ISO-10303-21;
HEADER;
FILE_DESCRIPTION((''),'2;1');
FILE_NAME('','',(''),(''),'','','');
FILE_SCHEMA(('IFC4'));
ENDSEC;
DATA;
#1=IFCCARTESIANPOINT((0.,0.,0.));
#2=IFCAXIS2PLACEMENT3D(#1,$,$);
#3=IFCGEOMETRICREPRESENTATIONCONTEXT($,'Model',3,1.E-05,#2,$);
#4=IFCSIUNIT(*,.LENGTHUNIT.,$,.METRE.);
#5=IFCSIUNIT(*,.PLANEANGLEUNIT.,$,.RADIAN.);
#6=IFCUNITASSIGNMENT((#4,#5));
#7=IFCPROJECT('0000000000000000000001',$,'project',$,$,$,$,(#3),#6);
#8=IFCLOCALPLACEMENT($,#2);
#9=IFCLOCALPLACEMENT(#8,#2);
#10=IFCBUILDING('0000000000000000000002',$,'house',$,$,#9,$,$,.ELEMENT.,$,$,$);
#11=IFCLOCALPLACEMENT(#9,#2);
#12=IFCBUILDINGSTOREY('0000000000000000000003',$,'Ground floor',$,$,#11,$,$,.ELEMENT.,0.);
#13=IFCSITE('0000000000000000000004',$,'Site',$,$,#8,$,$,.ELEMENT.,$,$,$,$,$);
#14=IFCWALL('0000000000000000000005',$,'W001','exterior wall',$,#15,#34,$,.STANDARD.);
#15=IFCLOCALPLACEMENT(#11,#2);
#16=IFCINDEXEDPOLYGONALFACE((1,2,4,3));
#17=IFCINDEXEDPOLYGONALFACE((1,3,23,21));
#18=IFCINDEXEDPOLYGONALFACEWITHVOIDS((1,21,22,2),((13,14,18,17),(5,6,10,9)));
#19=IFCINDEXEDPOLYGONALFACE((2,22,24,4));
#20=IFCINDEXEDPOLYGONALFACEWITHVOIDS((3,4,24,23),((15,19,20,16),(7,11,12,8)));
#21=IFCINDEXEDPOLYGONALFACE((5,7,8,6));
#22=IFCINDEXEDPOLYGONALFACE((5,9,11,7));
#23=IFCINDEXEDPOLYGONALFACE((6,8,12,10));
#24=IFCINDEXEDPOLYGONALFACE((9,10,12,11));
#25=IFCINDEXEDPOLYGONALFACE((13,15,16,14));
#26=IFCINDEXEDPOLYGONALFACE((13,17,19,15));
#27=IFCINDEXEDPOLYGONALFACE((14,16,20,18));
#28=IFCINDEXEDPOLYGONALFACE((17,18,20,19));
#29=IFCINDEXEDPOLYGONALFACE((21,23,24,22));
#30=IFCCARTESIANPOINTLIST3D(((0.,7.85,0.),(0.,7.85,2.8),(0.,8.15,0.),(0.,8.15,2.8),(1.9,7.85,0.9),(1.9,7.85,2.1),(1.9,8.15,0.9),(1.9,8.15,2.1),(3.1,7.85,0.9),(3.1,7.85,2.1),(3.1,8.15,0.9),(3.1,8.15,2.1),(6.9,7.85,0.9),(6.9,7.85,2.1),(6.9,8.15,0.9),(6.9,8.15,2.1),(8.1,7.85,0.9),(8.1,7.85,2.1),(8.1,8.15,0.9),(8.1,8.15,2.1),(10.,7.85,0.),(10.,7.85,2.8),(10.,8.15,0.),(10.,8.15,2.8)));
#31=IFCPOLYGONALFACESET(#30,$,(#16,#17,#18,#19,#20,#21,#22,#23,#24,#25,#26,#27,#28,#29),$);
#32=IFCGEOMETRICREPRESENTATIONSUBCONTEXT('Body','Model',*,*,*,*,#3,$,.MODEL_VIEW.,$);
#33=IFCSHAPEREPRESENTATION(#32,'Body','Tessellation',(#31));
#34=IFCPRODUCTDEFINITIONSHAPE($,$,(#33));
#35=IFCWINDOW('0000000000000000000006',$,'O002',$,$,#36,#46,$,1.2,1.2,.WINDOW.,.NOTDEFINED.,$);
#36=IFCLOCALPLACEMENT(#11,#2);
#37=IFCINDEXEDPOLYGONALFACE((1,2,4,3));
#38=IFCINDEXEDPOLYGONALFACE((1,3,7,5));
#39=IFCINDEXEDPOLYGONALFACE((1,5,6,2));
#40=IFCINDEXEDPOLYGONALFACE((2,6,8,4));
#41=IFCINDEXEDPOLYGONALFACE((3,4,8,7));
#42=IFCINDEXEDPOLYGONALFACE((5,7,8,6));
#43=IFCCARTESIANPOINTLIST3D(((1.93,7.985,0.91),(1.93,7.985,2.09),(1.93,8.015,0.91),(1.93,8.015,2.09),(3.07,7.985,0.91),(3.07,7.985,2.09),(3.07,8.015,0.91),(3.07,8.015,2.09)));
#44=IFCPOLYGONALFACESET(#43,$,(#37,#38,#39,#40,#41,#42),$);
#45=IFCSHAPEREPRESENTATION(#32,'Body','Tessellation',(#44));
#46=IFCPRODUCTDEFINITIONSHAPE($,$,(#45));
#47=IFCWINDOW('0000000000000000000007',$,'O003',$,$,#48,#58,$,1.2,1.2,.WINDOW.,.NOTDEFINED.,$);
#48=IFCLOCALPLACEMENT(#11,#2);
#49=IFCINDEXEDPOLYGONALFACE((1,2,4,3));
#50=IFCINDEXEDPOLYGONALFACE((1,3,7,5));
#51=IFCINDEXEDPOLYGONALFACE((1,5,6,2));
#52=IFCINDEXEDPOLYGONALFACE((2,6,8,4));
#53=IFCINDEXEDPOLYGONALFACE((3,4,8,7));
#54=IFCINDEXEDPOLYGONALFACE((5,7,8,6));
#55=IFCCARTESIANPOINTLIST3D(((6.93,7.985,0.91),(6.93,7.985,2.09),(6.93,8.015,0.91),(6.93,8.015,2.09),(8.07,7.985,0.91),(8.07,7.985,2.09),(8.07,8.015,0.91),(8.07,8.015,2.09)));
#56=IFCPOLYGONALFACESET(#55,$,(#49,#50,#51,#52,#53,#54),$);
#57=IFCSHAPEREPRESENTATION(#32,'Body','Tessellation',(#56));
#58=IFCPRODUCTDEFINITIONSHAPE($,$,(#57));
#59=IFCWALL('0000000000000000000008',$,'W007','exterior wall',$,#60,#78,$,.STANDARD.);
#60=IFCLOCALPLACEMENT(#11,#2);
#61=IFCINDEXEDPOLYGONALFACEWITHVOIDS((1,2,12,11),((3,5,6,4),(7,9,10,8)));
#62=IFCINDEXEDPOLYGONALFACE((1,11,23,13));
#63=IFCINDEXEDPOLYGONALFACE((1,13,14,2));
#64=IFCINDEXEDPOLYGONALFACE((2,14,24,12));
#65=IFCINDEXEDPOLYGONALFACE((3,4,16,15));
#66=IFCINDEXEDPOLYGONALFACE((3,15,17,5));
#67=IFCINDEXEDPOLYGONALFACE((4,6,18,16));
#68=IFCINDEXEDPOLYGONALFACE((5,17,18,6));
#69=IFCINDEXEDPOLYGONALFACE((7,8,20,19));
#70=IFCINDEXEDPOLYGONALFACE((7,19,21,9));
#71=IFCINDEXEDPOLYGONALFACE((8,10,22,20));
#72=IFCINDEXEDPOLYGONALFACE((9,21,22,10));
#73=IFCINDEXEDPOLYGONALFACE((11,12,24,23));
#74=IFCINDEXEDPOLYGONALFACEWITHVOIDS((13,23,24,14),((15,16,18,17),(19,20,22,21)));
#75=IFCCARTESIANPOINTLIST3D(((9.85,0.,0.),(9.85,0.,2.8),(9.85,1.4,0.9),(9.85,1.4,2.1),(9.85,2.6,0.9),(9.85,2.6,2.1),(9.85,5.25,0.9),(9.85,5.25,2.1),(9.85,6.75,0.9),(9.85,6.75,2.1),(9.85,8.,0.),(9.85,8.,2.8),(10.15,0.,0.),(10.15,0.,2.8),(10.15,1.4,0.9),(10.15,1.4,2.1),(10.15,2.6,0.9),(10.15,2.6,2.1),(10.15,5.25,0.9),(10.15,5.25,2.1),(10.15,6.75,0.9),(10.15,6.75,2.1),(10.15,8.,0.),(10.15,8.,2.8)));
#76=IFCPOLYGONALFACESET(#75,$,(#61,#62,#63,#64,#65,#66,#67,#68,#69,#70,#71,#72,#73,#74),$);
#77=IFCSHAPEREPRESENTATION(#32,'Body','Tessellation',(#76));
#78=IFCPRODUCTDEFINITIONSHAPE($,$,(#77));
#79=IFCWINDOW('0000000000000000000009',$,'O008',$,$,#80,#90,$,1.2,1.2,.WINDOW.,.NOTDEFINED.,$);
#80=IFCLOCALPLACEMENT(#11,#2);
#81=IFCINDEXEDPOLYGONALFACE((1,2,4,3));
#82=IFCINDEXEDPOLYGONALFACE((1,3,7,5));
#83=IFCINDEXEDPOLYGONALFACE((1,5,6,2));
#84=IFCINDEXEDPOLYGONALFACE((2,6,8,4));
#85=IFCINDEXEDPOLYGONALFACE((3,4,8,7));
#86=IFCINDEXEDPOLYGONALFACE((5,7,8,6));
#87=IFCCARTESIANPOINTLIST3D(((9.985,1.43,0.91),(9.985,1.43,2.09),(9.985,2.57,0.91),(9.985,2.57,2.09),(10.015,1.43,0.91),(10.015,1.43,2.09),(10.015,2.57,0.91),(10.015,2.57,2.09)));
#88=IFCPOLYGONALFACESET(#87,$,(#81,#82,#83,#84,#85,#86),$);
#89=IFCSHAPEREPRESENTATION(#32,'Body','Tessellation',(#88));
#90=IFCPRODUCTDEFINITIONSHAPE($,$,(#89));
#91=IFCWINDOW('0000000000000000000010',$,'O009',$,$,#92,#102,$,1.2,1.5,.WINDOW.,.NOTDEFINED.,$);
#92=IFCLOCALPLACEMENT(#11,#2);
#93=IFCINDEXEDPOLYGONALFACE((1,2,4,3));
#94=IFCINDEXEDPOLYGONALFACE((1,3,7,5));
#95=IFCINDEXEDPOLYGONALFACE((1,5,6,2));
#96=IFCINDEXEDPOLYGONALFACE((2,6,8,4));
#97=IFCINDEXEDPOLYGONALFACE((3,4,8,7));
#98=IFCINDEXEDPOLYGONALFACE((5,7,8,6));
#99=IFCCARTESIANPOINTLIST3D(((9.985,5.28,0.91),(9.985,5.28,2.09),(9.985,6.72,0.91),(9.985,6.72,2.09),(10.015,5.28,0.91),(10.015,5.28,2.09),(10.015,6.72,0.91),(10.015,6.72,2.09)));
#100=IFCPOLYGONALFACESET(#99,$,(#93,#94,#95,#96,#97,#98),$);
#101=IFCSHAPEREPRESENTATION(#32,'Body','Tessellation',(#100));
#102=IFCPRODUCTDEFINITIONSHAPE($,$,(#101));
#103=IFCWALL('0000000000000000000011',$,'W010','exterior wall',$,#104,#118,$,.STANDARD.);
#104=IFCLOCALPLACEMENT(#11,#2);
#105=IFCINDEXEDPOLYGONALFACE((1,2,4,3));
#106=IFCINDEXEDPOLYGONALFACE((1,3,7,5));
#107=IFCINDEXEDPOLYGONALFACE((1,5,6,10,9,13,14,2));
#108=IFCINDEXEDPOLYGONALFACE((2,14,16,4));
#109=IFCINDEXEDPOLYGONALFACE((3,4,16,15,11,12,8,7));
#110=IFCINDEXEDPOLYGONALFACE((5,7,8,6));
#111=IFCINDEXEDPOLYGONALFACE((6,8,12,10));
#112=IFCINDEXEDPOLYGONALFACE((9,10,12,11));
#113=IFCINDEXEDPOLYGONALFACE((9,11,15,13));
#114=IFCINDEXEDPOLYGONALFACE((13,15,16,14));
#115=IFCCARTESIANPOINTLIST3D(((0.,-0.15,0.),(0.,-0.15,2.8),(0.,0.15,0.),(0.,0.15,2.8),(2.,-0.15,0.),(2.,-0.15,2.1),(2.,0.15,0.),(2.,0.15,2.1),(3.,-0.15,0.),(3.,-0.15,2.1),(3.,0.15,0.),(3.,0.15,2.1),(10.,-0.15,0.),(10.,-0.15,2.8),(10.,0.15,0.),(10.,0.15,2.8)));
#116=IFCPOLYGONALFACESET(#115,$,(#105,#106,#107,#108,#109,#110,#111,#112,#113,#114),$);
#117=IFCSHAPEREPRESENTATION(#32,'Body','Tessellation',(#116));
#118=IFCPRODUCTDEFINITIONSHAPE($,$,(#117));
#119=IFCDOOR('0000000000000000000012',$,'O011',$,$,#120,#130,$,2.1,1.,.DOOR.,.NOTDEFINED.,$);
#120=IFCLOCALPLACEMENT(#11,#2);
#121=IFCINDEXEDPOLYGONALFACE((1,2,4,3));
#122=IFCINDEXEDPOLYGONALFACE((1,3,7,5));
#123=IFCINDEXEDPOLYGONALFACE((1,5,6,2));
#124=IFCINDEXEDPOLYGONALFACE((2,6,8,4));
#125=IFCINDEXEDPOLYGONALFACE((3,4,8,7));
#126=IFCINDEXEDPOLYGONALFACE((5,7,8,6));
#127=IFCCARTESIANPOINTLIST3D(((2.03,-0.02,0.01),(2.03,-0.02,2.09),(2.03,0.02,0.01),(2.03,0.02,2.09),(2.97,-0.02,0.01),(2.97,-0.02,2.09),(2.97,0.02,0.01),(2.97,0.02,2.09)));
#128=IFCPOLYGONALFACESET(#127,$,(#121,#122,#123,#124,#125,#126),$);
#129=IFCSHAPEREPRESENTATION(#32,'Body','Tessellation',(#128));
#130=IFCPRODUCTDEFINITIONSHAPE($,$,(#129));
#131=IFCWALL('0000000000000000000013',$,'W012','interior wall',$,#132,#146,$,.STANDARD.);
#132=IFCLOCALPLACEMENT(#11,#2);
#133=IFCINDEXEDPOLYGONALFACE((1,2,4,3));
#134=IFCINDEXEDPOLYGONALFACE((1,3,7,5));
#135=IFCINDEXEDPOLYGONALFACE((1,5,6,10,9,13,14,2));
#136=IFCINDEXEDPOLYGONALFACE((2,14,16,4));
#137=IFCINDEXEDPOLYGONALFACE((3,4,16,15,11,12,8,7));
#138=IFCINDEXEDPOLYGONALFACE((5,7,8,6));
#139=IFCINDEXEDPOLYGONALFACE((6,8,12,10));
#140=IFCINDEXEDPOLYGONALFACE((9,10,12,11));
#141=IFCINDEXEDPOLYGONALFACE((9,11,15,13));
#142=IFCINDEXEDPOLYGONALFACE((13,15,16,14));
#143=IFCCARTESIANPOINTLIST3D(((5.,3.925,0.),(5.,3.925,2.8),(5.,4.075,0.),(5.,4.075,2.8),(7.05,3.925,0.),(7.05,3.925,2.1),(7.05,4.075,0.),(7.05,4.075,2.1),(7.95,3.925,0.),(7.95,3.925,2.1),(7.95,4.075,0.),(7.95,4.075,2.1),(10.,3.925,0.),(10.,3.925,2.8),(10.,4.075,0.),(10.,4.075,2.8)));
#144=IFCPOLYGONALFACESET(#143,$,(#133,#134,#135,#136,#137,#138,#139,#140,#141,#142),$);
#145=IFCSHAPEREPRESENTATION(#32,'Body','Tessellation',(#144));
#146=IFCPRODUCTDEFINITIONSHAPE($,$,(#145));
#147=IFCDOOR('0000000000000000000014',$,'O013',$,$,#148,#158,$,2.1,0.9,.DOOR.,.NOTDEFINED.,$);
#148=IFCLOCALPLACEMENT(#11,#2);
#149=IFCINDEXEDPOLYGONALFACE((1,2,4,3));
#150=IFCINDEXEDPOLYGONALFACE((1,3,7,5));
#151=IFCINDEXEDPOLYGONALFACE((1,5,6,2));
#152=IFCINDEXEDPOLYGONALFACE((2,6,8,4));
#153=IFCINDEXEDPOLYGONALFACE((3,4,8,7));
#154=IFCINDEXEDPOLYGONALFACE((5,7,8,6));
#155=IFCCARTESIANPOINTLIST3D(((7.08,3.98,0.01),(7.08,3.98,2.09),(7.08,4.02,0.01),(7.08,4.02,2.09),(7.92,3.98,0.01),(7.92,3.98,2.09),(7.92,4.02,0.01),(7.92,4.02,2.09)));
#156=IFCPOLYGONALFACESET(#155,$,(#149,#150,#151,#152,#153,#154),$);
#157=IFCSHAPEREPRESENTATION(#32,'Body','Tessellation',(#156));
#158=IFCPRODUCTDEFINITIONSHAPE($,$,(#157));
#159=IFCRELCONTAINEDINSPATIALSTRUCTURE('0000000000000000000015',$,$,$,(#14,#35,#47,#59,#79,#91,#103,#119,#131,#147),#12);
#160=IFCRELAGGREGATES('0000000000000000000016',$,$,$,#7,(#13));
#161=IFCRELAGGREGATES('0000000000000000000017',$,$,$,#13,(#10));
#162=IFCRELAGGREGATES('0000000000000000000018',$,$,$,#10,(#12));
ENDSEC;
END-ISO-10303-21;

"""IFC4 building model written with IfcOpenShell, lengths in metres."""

from ifc_helpers import new_model, si_unit, frame, origin, origin_2d, place, context, subcontext, project, spatial, rectangle, extrude, element, fill, save


model = new_model("IFC4")

# Units and contexts
model_context = context("Model", 3, precision=1e-05, world=origin())
body_context = subcontext(model_context, "Body", "Model", "MODEL_VIEW")
ifc_project = project(units=[si_unit("LENGTHUNIT", "METRE"), si_unit("PLANEANGLEUNIT", "RADIAN")], contexts=[model_context])

# Site, building, storey
site_placement = place(None, origin())
site = spatial("IfcSite", under=ifc_project, at=site_placement, Name="Site", CompositionType="ELEMENT")
building_placement = place(site_placement, origin())
building = spatial("IfcBuilding", under=site, at=building_placement, Name="house", CompositionType="ELEMENT")
storey_placement = place(building_placement, origin())
storey = spatial("IfcBuildingStorey", under=building, at=storey_placement, Name="Ground floor", CompositionType="ELEMENT", Elevation=0.0)

# Walls, openings, windows
wall_1_placement = place(storey_placement, frame((5.0, 8.0, 0.0), z_axis=(0.0, 0.0, 1.0), x_axis=(1.0, 0.0, 0.0)))
wall_1 = element("IfcWall", 1, at=wall_1_placement, inside=storey, Name="W001", Description="exterior wall", PredefinedType="STANDARD", context=body_context, shape_type="SweptSolid", body=[
    extrude(rectangle(XDim=10.0, YDim=0.3, at=origin_2d()), origin(), (0.0, 0.0, 1.0), 2.8),
])
opening_1_placement = place(wall_1_placement, frame((-2.5, 0.0, 0.9)))
opening_1 = element("IfcOpeningElement", 2, at=opening_1_placement, cuts=wall_1, PredefinedType="OPENING", context=body_context, shape_type="SweptSolid", body=[
    extrude(rectangle(XDim=1.2, YDim=0.36, at=origin_2d()), origin(), (0.0, 0.0, 1.0), 1.2),
])
opening_2_placement = place(wall_1_placement, frame((2.5, 0.0, 0.9)))
opening_2 = element("IfcOpeningElement", 3, at=opening_2_placement, cuts=wall_1, PredefinedType="OPENING", context=body_context, shape_type="SweptSolid", body=[
    extrude(rectangle(XDim=1.2, YDim=0.36, at=origin_2d()), origin(), (0.0, 0.0, 1.0), 1.2),
])
window_1_placement = place(wall_1_placement, frame((-2.5, 0.0, 0.9)))
window_1 = element("IfcWindow", 4, at=window_1_placement, inside=storey, Name="O002", OverallHeight=1.2, OverallWidth=1.2, PartitioningType="NOTDEFINED", PredefinedType="WINDOW", context=body_context, shape_type="SweptSolid", body=[
    extrude(rectangle(XDim=1.14, YDim=0.03, at=origin_2d()), frame((0.0, 0.0, 0.01)), (0.0, 0.0, 1.0), 1.18),
])
fill(opening_1, window_1)
window_2_placement = place(wall_1_placement, frame((2.5, 0.0, 0.9)))
window_2 = element("IfcWindow", 5, at=window_2_placement, inside=storey, Name="O003", OverallHeight=1.2, OverallWidth=1.2, PartitioningType="NOTDEFINED", PredefinedType="WINDOW", context=body_context, shape_type="SweptSolid", body=[
    extrude(rectangle(XDim=1.14, YDim=0.03, at=origin_2d()), frame((0.0, 0.0, 0.01)), (0.0, 0.0, 1.0), 1.18),
])
fill(opening_2, window_2)
wall_2_placement = place(storey_placement, frame((10.0, 4.0, 0.0), z_axis=(0.0, 0.0, 1.0), x_axis=(0.0, 1.0, 0.0)))
wall_2 = element("IfcWall", 6, at=wall_2_placement, inside=storey, Name="W007", Description="exterior wall", PredefinedType="STANDARD", context=body_context, shape_type="SweptSolid", body=[
    extrude(rectangle(XDim=8.0, YDim=0.3, at=origin_2d()), origin(), (0.0, 0.0, 1.0), 2.8),
])
opening_3_placement = place(wall_2_placement, frame((-2.0, 0.0, 0.9)))
opening_3 = element("IfcOpeningElement", 7, at=opening_3_placement, cuts=wall_2, PredefinedType="OPENING", context=body_context, shape_type="SweptSolid", body=[
    extrude(rectangle(XDim=1.2, YDim=0.36, at=origin_2d()), origin(), (0.0, 0.0, 1.0), 1.2),
])
opening_4_placement = place(wall_2_placement, frame((2.0, 0.0, 0.9)))
opening_4 = element("IfcOpeningElement", 8, at=opening_4_placement, cuts=wall_2, PredefinedType="OPENING", context=body_context, shape_type="SweptSolid", body=[
    extrude(rectangle(XDim=1.5, YDim=0.36, at=origin_2d()), origin(), (0.0, 0.0, 1.0), 1.2),
])
window_3_placement = place(wall_2_placement, frame((-2.0, 0.0, 0.9)))
window_3 = element("IfcWindow", 9, at=window_3_placement, inside=storey, Name="O008", OverallHeight=1.2, OverallWidth=1.2, PartitioningType="NOTDEFINED", PredefinedType="WINDOW", context=body_context, shape_type="SweptSolid", body=[
    extrude(rectangle(XDim=1.14, YDim=0.03, at=origin_2d()), frame((0.0, 0.0, 0.01)), (0.0, 0.0, 1.0), 1.18),
])
fill(opening_3, window_3)
window_4_placement = place(wall_2_placement, frame((2.0, 0.0, 0.9)))
window_4 = element("IfcWindow", 10, at=window_4_placement, inside=storey, Name="O009", OverallHeight=1.2, OverallWidth=1.5, PartitioningType="NOTDEFINED", PredefinedType="WINDOW", context=body_context, shape_type="SweptSolid", body=[
    extrude(rectangle(XDim=1.44, YDim=0.03, at=origin_2d()), frame((0.0, 0.0, 0.01)), (0.0, 0.0, 1.0), 1.18),
])
fill(opening_4, window_4)

# Walls, openings, doors
wall_3_placement = place(storey_placement, frame((5.0, 0.0, 0.0), z_axis=(0.0, 0.0, 1.0), x_axis=(1.0, 0.0, 0.0)))
wall_3 = element("IfcWall", 11, at=wall_3_placement, inside=storey, Name="W010", Description="exterior wall", PredefinedType="STANDARD", context=body_context, shape_type="SweptSolid", body=[
    extrude(rectangle(XDim=10.0, YDim=0.3, at=origin_2d()), origin(), (0.0, 0.0, 1.0), 2.8),
])
opening_5_placement = place(wall_3_placement, frame((-2.5, 0.0, 0.0)))
opening_5 = element("IfcOpeningElement", 12, at=opening_5_placement, cuts=wall_3, PredefinedType="OPENING", context=body_context, shape_type="SweptSolid", body=[
    extrude(rectangle(XDim=1.0, YDim=0.36, at=origin_2d()), origin(), (0.0, 0.0, 1.0), 2.1),
])
door_1_placement = place(wall_3_placement, frame((-2.5, 0.0, 0.0)))
door_1 = element("IfcDoor", 13, at=door_1_placement, inside=storey, Name="O011", OperationType="NOTDEFINED", OverallHeight=2.1, OverallWidth=1.0, PredefinedType="DOOR", context=body_context, shape_type="SweptSolid", body=[
    extrude(rectangle(XDim=0.94, YDim=0.04, at=origin_2d()), frame((0.0, 0.0, 0.01)), (0.0, 0.0, 1.0), 2.08),
])
fill(opening_5, door_1)
wall_4_placement = place(storey_placement, frame((7.5, 4.0, 0.0), z_axis=(0.0, 0.0, 1.0), x_axis=(1.0, 0.0, 0.0)))
wall_4 = element("IfcWall", 14, at=wall_4_placement, inside=storey, Name="W012", Description="interior wall", PredefinedType="STANDARD", context=body_context, shape_type="SweptSolid", body=[
    extrude(rectangle(XDim=5.0, YDim=0.15, at=origin_2d()), origin(), (0.0, 0.0, 1.0), 2.8),
])
opening_6_placement = place(wall_4_placement, origin())
opening_6 = element("IfcOpeningElement", 15, at=opening_6_placement, cuts=wall_4, PredefinedType="OPENING", context=body_context, shape_type="SweptSolid", body=[
    extrude(rectangle(XDim=0.9, YDim=0.18, at=origin_2d()), origin(), (0.0, 0.0, 1.0), 2.1),
])
door_2_placement = place(wall_4_placement, origin())
door_2 = element("IfcDoor", 16, at=door_2_placement, inside=storey, Name="O013", OperationType="NOTDEFINED", OverallHeight=2.1, OverallWidth=0.9, PredefinedType="DOOR", context=body_context, shape_type="SweptSolid", body=[
    extrude(rectangle(XDim=0.84, YDim=0.04, at=origin_2d()), frame((0.0, 0.0, 0.01)), (0.0, 0.0, 1.0), 2.08),
])
fill(opening_6, door_2)

save(model, "model.ifc")
